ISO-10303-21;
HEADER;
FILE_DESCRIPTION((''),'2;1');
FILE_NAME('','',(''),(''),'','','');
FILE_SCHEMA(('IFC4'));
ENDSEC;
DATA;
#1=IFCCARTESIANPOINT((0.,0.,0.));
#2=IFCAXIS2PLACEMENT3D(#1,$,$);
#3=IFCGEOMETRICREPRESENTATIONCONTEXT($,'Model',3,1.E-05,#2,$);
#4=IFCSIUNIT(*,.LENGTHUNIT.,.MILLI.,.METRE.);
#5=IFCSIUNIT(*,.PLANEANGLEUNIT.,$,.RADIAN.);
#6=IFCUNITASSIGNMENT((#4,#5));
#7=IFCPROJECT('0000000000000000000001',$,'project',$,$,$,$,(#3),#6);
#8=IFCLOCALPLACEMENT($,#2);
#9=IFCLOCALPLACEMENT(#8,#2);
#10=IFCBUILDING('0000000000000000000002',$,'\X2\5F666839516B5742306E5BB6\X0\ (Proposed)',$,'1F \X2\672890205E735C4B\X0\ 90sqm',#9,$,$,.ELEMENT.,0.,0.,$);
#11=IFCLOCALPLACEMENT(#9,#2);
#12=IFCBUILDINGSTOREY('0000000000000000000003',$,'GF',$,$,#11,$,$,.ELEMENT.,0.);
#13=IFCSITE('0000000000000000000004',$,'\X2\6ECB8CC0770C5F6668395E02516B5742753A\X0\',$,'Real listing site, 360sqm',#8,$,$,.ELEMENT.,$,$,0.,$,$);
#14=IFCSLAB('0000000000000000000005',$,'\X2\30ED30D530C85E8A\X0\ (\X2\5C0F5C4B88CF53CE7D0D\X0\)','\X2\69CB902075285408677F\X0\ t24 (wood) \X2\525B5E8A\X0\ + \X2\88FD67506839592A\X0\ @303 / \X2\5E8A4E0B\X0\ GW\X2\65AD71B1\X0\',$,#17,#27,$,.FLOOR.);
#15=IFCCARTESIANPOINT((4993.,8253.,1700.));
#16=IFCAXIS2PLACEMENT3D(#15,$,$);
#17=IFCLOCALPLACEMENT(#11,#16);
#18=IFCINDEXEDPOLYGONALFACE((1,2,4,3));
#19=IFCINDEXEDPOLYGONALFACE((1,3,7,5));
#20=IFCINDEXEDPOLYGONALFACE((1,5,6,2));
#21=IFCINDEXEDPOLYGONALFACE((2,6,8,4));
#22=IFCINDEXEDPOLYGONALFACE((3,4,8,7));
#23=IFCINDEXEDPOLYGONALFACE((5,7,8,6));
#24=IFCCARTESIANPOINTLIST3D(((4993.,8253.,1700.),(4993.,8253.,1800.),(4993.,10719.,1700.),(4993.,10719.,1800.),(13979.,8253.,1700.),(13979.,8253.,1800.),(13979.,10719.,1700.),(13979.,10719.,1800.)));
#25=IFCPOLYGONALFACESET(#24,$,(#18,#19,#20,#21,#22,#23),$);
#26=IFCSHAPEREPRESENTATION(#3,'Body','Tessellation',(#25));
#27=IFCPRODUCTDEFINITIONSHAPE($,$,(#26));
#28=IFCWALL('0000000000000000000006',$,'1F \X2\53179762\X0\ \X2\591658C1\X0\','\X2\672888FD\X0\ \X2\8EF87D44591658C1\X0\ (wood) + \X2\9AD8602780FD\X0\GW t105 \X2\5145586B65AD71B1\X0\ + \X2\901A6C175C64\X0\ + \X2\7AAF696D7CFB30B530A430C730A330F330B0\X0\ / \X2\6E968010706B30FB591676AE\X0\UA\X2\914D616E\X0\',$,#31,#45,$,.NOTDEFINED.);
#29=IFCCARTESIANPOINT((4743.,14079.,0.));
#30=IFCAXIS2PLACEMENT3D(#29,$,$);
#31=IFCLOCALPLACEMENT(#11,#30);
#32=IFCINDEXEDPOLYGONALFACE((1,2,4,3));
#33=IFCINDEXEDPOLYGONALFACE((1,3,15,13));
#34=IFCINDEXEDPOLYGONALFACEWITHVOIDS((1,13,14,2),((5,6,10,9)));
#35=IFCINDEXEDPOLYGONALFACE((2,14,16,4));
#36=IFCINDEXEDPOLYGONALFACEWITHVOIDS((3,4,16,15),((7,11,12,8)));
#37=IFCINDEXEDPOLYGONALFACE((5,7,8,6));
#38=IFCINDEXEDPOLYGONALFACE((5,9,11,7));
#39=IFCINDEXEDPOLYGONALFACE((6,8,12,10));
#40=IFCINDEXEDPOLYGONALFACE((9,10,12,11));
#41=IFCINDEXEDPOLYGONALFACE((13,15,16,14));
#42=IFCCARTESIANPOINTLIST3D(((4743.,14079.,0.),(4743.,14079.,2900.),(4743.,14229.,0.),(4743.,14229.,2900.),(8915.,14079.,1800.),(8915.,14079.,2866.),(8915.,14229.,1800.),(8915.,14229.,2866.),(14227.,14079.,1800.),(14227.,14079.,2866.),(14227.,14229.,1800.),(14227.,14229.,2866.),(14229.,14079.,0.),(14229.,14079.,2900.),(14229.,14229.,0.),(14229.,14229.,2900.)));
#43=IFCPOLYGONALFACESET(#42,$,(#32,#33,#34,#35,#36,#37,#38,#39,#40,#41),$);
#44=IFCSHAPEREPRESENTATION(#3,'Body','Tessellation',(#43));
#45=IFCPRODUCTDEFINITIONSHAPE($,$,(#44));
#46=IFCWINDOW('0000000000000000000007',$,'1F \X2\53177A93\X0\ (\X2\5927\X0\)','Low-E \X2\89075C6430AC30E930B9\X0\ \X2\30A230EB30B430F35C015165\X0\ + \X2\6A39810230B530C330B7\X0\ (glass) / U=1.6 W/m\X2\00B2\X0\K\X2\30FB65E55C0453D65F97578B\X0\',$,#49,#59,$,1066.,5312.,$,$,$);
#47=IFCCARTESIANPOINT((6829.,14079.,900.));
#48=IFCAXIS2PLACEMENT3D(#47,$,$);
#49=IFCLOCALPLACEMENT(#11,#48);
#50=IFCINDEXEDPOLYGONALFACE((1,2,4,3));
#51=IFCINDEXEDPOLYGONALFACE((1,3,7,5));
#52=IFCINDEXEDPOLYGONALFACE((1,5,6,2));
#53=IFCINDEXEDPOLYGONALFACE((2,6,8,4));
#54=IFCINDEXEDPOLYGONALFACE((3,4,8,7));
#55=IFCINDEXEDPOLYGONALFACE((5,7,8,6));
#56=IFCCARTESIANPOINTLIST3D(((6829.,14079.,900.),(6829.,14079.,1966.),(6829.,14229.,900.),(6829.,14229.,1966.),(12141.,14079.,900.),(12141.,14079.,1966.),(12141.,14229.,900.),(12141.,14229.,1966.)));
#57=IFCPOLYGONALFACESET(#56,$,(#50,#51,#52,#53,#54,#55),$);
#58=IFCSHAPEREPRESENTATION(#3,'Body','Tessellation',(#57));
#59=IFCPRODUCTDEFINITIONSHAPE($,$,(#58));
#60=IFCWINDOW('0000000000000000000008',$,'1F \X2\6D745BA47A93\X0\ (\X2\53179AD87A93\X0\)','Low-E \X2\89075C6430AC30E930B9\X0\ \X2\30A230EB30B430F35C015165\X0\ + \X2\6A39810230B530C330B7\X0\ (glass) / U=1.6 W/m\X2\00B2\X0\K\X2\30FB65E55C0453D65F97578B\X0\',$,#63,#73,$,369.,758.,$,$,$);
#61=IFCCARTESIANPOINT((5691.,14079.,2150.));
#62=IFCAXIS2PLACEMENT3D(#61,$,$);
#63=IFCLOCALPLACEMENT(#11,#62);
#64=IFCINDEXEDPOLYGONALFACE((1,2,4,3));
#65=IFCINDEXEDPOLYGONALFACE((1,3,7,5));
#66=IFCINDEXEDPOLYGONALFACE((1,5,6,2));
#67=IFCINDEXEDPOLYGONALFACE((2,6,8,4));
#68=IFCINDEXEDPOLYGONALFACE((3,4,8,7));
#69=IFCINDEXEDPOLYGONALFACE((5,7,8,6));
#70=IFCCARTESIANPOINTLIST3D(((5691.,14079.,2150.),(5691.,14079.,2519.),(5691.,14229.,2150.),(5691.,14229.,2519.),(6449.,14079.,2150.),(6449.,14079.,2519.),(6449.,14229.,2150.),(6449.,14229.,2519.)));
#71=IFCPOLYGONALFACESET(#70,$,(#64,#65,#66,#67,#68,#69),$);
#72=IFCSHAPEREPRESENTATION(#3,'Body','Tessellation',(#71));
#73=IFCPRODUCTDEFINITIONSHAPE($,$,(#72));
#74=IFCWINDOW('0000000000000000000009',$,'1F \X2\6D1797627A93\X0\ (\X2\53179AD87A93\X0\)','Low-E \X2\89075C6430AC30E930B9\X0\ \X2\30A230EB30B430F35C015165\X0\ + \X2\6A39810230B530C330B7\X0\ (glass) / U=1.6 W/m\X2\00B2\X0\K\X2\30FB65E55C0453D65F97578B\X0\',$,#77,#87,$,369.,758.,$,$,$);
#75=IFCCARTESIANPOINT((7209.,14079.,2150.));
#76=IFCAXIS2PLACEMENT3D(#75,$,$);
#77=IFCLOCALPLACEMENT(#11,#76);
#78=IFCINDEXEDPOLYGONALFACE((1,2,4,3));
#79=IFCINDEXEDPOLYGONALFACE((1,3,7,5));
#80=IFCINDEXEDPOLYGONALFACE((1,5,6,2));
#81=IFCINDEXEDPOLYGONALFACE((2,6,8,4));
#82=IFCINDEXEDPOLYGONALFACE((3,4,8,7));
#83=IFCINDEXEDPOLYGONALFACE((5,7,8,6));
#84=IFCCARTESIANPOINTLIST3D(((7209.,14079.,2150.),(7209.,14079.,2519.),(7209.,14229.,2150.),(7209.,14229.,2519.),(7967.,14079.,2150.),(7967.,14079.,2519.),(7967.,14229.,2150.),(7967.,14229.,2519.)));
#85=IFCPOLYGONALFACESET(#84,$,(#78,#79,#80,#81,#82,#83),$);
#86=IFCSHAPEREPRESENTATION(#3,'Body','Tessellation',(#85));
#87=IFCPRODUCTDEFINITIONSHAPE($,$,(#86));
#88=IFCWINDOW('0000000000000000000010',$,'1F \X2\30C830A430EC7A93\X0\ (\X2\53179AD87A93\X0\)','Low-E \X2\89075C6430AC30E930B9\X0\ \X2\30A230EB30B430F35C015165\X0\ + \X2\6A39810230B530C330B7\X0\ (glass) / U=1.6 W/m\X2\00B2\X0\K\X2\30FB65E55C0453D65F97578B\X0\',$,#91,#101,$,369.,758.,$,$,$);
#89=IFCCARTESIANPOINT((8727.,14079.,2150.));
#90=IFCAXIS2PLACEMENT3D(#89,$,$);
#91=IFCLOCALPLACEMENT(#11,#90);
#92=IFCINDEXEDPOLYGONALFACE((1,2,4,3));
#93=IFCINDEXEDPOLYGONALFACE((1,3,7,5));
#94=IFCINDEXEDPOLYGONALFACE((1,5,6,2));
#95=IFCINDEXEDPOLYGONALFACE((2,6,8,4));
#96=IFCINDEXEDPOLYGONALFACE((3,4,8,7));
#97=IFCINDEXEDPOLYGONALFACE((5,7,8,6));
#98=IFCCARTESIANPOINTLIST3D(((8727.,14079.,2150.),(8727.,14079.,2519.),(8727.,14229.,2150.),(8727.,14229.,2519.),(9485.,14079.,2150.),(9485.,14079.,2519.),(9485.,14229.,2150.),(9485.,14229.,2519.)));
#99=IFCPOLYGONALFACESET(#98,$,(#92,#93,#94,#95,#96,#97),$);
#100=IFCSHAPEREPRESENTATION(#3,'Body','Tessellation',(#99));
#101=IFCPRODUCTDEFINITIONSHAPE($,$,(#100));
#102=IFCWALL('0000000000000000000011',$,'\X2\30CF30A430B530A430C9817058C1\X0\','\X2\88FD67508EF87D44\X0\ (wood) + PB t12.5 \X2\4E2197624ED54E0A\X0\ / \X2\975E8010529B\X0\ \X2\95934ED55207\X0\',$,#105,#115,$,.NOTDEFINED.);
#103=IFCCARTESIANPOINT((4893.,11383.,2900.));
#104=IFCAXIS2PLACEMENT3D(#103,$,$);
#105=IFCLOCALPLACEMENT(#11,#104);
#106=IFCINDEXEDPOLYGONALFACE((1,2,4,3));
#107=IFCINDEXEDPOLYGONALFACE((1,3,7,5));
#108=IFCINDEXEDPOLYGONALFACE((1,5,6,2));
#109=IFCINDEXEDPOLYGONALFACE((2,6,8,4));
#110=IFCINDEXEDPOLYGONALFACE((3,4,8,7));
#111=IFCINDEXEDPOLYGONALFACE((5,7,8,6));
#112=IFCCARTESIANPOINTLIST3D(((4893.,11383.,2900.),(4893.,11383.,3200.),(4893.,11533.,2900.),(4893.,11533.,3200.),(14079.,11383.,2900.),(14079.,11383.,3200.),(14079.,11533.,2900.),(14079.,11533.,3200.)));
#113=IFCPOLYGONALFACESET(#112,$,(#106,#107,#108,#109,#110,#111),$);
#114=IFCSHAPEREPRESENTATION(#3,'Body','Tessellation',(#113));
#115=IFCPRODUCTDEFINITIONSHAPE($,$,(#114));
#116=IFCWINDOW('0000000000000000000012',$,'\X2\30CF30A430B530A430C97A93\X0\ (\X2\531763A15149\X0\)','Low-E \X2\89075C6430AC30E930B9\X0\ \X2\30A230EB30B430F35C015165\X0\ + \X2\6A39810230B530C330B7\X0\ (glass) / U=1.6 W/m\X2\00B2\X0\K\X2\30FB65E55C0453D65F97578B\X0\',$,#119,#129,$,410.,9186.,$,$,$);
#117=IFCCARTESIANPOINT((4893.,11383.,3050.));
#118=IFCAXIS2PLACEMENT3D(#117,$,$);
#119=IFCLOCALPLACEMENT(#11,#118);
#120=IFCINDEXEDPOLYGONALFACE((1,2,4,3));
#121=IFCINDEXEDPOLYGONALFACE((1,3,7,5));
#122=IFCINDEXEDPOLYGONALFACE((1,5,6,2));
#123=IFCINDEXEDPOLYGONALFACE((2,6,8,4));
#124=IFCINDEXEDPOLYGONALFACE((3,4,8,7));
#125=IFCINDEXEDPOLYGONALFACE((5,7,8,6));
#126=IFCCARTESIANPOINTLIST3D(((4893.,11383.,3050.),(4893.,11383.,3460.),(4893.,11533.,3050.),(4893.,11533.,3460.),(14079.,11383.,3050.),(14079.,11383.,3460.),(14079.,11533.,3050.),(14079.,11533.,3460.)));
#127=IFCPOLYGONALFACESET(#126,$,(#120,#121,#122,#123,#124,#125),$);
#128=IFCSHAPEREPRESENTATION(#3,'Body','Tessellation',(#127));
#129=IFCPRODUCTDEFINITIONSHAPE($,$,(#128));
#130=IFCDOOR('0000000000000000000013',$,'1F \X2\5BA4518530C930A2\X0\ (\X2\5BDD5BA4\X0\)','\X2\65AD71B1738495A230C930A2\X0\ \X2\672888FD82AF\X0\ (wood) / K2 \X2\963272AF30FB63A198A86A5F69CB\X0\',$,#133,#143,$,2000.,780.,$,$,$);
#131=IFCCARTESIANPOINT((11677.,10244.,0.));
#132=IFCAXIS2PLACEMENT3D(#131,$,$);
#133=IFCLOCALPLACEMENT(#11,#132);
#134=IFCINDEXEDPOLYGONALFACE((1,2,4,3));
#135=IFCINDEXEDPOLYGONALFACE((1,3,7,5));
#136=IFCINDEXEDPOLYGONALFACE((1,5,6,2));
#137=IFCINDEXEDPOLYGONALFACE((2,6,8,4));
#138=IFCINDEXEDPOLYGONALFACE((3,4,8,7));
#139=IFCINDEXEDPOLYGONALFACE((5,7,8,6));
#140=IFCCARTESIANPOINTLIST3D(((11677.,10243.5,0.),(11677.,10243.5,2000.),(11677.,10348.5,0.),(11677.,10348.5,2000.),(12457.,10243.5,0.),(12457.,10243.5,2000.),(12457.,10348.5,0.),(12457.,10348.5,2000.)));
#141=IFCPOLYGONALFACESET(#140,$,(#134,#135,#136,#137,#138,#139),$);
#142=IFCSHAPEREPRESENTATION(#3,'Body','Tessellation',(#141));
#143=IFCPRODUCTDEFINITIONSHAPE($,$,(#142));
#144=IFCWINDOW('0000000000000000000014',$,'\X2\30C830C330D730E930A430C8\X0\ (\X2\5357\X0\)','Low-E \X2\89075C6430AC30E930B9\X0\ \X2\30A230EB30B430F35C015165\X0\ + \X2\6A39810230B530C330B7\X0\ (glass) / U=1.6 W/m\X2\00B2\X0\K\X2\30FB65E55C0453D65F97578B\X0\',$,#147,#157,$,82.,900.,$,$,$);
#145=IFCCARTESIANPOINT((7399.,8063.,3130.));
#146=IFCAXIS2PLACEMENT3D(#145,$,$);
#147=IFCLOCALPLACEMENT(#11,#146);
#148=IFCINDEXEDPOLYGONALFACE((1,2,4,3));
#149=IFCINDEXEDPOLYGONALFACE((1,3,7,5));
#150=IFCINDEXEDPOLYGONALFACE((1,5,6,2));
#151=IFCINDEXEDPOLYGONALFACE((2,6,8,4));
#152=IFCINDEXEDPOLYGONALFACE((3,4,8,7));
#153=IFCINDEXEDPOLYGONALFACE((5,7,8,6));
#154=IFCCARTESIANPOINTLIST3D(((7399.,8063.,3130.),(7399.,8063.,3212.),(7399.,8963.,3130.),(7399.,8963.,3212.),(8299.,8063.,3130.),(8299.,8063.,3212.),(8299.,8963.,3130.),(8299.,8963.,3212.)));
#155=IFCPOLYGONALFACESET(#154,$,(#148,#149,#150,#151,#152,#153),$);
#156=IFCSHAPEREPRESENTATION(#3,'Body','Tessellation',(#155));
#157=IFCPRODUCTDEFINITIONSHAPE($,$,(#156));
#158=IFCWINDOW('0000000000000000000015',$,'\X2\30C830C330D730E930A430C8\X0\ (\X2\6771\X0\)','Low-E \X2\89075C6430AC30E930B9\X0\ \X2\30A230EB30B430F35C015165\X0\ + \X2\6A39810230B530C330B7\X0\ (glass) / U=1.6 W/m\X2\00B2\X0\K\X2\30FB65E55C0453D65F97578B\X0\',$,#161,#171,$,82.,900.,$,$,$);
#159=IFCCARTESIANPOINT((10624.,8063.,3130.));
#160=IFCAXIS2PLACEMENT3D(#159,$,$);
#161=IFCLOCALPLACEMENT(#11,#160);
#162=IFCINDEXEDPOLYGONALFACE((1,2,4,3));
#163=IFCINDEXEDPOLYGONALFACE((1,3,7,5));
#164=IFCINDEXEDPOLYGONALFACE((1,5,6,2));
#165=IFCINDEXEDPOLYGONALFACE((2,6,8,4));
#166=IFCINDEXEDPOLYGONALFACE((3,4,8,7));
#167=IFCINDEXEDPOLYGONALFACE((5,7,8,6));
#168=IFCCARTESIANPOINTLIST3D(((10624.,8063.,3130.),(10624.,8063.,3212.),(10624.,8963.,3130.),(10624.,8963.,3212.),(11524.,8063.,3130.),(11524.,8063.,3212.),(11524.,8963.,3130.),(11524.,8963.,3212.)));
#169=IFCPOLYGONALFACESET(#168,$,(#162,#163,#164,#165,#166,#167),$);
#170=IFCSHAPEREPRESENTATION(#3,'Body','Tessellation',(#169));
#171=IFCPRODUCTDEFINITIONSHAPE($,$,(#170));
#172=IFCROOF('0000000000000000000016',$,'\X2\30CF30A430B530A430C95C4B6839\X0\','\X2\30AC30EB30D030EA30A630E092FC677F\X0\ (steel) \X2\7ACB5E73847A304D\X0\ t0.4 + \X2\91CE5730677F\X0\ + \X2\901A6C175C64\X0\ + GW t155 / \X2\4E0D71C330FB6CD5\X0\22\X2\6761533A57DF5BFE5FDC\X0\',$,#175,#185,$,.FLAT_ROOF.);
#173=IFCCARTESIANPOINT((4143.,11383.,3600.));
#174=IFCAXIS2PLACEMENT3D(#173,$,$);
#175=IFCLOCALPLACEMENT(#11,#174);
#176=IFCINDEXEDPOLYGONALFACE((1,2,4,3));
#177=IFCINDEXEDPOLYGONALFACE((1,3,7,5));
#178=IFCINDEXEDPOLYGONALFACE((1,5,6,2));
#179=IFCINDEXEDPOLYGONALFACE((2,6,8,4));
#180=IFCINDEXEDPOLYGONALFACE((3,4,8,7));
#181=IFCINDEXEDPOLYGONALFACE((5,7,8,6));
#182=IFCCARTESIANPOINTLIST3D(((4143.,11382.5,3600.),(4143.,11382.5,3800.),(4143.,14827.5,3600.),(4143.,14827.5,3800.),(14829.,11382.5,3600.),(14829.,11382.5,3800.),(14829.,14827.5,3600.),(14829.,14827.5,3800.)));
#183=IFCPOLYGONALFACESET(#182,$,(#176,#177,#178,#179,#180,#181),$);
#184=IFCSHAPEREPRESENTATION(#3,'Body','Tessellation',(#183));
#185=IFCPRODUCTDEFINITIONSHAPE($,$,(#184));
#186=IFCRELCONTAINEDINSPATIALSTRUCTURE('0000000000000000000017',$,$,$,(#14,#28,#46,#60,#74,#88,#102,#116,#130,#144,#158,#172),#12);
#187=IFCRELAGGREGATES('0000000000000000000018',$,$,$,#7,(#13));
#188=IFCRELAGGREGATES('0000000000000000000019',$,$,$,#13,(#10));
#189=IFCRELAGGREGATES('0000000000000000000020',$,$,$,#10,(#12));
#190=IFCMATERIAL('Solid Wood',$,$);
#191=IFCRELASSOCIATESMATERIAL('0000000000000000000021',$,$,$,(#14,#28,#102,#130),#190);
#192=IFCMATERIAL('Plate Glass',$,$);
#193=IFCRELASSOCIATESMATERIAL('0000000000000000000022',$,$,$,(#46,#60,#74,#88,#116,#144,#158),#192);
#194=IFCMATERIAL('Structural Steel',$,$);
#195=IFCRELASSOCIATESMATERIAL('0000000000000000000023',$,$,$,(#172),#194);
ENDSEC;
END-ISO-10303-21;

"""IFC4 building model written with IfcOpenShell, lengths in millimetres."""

from ifc_helpers import new_model, si_unit, frame, frame_2d, origin, place, context, project, spatial, rectangle, extrude, material, element, fill, save


model = new_model("IFC4")

# Units and contexts
model_context = context("Model", 3, precision=1e-05, world=origin())
ifc_project = project(units=[si_unit("LENGTHUNIT", "METRE", prefix="MILLI"), si_unit("PLANEANGLEUNIT", "RADIAN")], contexts=[model_context])

# Site, building, storey
site_placement = place(None, origin())
site = spatial("IfcSite", under=ifc_project, at=site_placement, Name="滋賀県彦根市八坂町", ObjectType="Real listing site, 360sqm", CompositionType="ELEMENT", RefElevation=0.0)
building_placement = place(site_placement, origin())
building = spatial("IfcBuilding", under=site, at=building_placement, Name="彦根八坂の家 (Proposed)", ObjectType="1F 木造平屋 90sqm", CompositionType="ELEMENT", ElevationOfRefHeight=0.0, ElevationOfTerrain=0.0)
storey_placement = place(building_placement, origin())
storey = spatial("IfcBuildingStorey", under=building, at=storey_placement, Name="GF", CompositionType="ELEMENT", Elevation=0.0)

# Slab
ifc_material_1 = material(Name="Solid Wood")
slab_placement = place(storey_placement, frame((4993.0, 8253.0, 1700.0)))
element("IfcSlab", 1, at=slab_placement, inside=storey, material=ifc_material_1, Name="ロフト床 (小屋裏収納)", Description="構造用合板 t24 (wood) 剛床 + 製材根太 @303 / 床下 GW断熱", PredefinedType="FLOOR", context=model_context, shape_type="SweptSolid", body=[
    extrude(rectangle(XDim=8986.0, YDim=2466.0, at=frame_2d((4493.0, 1233.0))), frame((4993.0, 8253.0, 1700.0)), (0.0, 0.0, 1.0), 100.0),
])

# Wall, openings, windows
wall_1_placement = place(storey_placement, frame((4743.0, 14079.0, 0.0)))
wall_1 = element("IfcWall", 2, at=wall_1_placement, inside=storey, material=ifc_material_1, Name="1F 北面 外壁", Description="木製 軸組外壁 (wood) + 高性能GW t105 充填断熱 + 通気層 + 窯業系サイディング / 準耐火・外皮UA配慮", PredefinedType="NOTDEFINED", context=model_context, shape_type="SweptSolid", body=[
    extrude(rectangle(XDim=9486.0, YDim=150.0, at=frame_2d((4743.0, 75.0))), frame((4743.0, 14079.0, 0.0)), (0.0, 0.0, 1.0), 2900.0),
])
opening_1_placement = place(storey_placement, frame((6829.0, 14079.0, 900.0)))
opening_1 = element("IfcOpeningElement", 3, at=opening_1_placement, cuts=wall_1, PredefinedType="NOTDEFINED", context=model_context, shape_type="SweptSolid", body=[
    extrude(rectangle(XDim=5312.0, YDim=150.0, at=frame_2d((2656.0, 75.0))), frame((6829.0, 14079.0, 900.0)), (0.0, 0.0, 1.0), 1066.0),
])
opening_2_placement = place(storey_placement, frame((5691.0, 14079.0, 2150.0)))
opening_2 = element("IfcOpeningElement", 4, at=opening_2_placement, cuts=wall_1, PredefinedType="NOTDEFINED", context=model_context, shape_type="SweptSolid", body=[
    extrude(rectangle(XDim=758.0, YDim=150.0, at=frame_2d((379.0, 75.0))), frame((5691.0, 14079.0, 2150.0)), (0.0, 0.0, 1.0), 369.0),
])
opening_3_placement = place(storey_placement, frame((7209.0, 14079.0, 2150.0)))
opening_3 = element("IfcOpeningElement", 5, at=opening_3_placement, cuts=wall_1, PredefinedType="NOTDEFINED", context=model_context, shape_type="SweptSolid", body=[
    extrude(rectangle(XDim=758.0, YDim=150.0, at=frame_2d((379.0, 75.0))), frame((7209.0, 14079.0, 2150.0)), (0.0, 0.0, 1.0), 369.0),
])
opening_4_placement = place(storey_placement, frame((8727.0, 14079.0, 2150.0)))
opening_4 = element("IfcOpeningElement", 6, at=opening_4_placement, cuts=wall_1, PredefinedType="NOTDEFINED", context=model_context, shape_type="SweptSolid", body=[
    extrude(rectangle(XDim=758.0, YDim=150.0, at=frame_2d((379.0, 75.0))), frame((8727.0, 14079.0, 2150.0)), (0.0, 0.0, 1.0), 369.0),
])
ifc_material_2 = material(Name="Plate Glass")
window_1_placement = place(storey_placement, frame((6829.0, 14079.0, 900.0)))
window_1 = element("IfcWindow", 7, at=window_1_placement, inside=storey, material=ifc_material_2, Name="1F 北窓 (大)", Description="Low-E 複層ガラス アルゴン封入 + 樹脂サッシ (glass) / U=1.6 W/m²K・日射取得型", OverallHeight=1066.0, OverallWidth=5312.0, context=model_context, shape_type="SweptSolid", body=[
    extrude(rectangle(XDim=5312.0, YDim=150.0, at=frame_2d((2656.0, 75.0))), frame((6829.0, 14079.0, 900.0)), (0.0, 0.0, 1.0), 1066.0),
])
fill(opening_1, window_1)
window_2_placement = place(storey_placement, frame((5691.0, 14079.0, 2150.0)))
window_2 = element("IfcWindow", 8, at=window_2_placement, inside=storey, material=ifc_material_2, Name="1F 浴室窓 (北高窓)", Description="Low-E 複層ガラス アルゴン封入 + 樹脂サッシ (glass) / U=1.6 W/m²K・日射取得型", OverallHeight=369.0, OverallWidth=758.0, context=model_context, shape_type="SweptSolid", body=[
    extrude(rectangle(XDim=758.0, YDim=150.0, at=frame_2d((379.0, 75.0))), frame((5691.0, 14079.0, 2150.0)), (0.0, 0.0, 1.0), 369.0),
])
fill(opening_2, window_2)
window_3_placement = place(storey_placement, frame((7209.0, 14079.0, 2150.0)))
window_3 = element("IfcWindow", 9, at=window_3_placement, inside=storey, material=ifc_material_2, Name="1F 洗面窓 (北高窓)", Description="Low-E 複層ガラス アルゴン封入 + 樹脂サッシ (glass) / U=1.6 W/m²K・日射取得型", OverallHeight=369.0, OverallWidth=758.0, context=model_context, shape_type="SweptSolid", body=[
    extrude(rectangle(XDim=758.0, YDim=150.0, at=frame_2d((379.0, 75.0))), frame((7209.0, 14079.0, 2150.0)), (0.0, 0.0, 1.0), 369.0),
])
fill(opening_3, window_3)
window_4_placement = place(storey_placement, frame((8727.0, 14079.0, 2150.0)))
window_4 = element("IfcWindow", 10, at=window_4_placement, inside=storey, material=ifc_material_2, Name="1F トイレ窓 (北高窓)", Description="Low-E 複層ガラス アルゴン封入 + 樹脂サッシ (glass) / U=1.6 W/m²K・日射取得型", OverallHeight=369.0, OverallWidth=758.0, context=model_context, shape_type="SweptSolid", body=[
    extrude(rectangle(XDim=758.0, YDim=150.0, at=frame_2d((379.0, 75.0))), frame((8727.0, 14079.0, 2150.0)), (0.0, 0.0, 1.0), 369.0),
])
fill(opening_4, window_4)

# Wall, opening, window
wall_2_placement = place(storey_placement, frame((4893.0, 11383.0, 2900.0)))
wall_2 = element("IfcWall", 11, at=wall_2_placement, inside=storey, material=ifc_material_1, Name="ハイサイド腰壁", Description="製材軸組 (wood) + PB t12.5 両面仕上 / 非耐力 間仕切", PredefinedType="NOTDEFINED", context=model_context, shape_type="SweptSolid", body=[
    extrude(rectangle(XDim=9186.0, YDim=150.0, at=frame_2d((4593.0, 75.0))), frame((4893.0, 11383.0, 2900.0)), (0.0, 0.0, 1.0), 700.0),
])
opening_5_placement = place(storey_placement, frame((4893.0, 11383.0, 3050.0)))
opening_5 = element("IfcOpeningElement", 12, at=opening_5_placement, cuts=wall_2, PredefinedType="NOTDEFINED", context=model_context, shape_type="SweptSolid", body=[
    extrude(rectangle(XDim=9186.0, YDim=150.0, at=frame_2d((4593.0, 75.0))), frame((4893.0, 11383.0, 3050.0)), (0.0, 0.0, 1.0), 410.0),
])
window_5_placement = place(storey_placement, frame((4893.0, 11383.0, 3050.0)))
window_5 = element("IfcWindow", 13, at=window_5_placement, inside=storey, material=ifc_material_2, Name="ハイサイド窓 (北採光)", Description="Low-E 複層ガラス アルゴン封入 + 樹脂サッシ (glass) / U=1.6 W/m²K・日射取得型", OverallHeight=410.0, OverallWidth=9186.0, context=model_context, shape_type="SweptSolid", body=[
    extrude(rectangle(XDim=9186.0, YDim=150.0, at=frame_2d((4593.0, 75.0))), frame((4893.0, 11383.0, 3050.0)), (0.0, 0.0, 1.0), 410.0),
])
fill(opening_5, window_5)

# Door
door_1_placement = place(storey_placement, frame((11677.0, 10244.0, 0.0)))
element("IfcDoor", 14, at=door_1_placement, inside=storey, material=ifc_material_1, Name="1F 室内ドア (寝室)", Description="断熱玄関ドア 木製芯 (wood) / K2 防犯・採風機構", OverallHeight=2000.0, OverallWidth=780.0, context=model_context, shape_type="SweptSolid", body=[
    extrude(rectangle(XDim=780.0, YDim=105.0, at=frame_2d((390.0, 52.0))), frame((11677.0, 10244.0, 0.0)), (0.0, 0.0, 1.0), 2000.0),
])

# Windows
window_6_placement = place(storey_placement, frame((7399.0, 8063.0, 3130.0)))
element("IfcWindow", 15, at=window_6_placement, inside=storey, material=ifc_material_2, Name="トップライト (南)", Description="Low-E 複層ガラス アルゴン封入 + 樹脂サッシ (glass) / U=1.6 W/m²K・日射取得型", OverallHeight=82.0, OverallWidth=900.0, context=model_context, shape_type="SweptSolid", body=[
    extrude(rectangle(XDim=900.0, YDim=900.0, at=frame_2d((450.0, 450.0))), frame((7399.0, 8063.0, 3130.0)), (0.0, 0.0, 1.0), 82.0),
])
window_7_placement = place(storey_placement, frame((10624.0, 8063.0, 3130.0)))
element("IfcWindow", 16, at=window_7_placement, inside=storey, material=ifc_material_2, Name="トップライト (東)", Description="Low-E 複層ガラス アルゴン封入 + 樹脂サッシ (glass) / U=1.6 W/m²K・日射取得型", OverallHeight=82.0, OverallWidth=900.0, context=model_context, shape_type="SweptSolid", body=[
    extrude(rectangle(XDim=900.0, YDim=900.0, at=frame_2d((450.0, 450.0))), frame((10624.0, 8063.0, 3130.0)), (0.0, 0.0, 1.0), 82.0),
])

# Roof
ifc_material_3 = material(Name="Structural Steel")
roof_placement = place(storey_placement, frame((4143.0, 11383.0, 3600.0)))
element("IfcRoof", 17, at=roof_placement, inside=storey, material=ifc_material_3, Name="ハイサイド屋根", Description="ガルバリウム鋼板 (steel) 立平葺き t0.4 + 野地板 + 通気層 + GW t155 / 不燃・法22条区域対応", PredefinedType="FLAT_ROOF", context=model_context, shape_type="SweptSolid", body=[
    extrude(rectangle(XDim=10686.0, YDim=3445.0, at=frame_2d((5343.0, 1722.0))), frame((4143.0, 11383.0, 3600.0)), (0.0, 0.0, 1.0), 200.0),
])

save(model, "model.ifc")
